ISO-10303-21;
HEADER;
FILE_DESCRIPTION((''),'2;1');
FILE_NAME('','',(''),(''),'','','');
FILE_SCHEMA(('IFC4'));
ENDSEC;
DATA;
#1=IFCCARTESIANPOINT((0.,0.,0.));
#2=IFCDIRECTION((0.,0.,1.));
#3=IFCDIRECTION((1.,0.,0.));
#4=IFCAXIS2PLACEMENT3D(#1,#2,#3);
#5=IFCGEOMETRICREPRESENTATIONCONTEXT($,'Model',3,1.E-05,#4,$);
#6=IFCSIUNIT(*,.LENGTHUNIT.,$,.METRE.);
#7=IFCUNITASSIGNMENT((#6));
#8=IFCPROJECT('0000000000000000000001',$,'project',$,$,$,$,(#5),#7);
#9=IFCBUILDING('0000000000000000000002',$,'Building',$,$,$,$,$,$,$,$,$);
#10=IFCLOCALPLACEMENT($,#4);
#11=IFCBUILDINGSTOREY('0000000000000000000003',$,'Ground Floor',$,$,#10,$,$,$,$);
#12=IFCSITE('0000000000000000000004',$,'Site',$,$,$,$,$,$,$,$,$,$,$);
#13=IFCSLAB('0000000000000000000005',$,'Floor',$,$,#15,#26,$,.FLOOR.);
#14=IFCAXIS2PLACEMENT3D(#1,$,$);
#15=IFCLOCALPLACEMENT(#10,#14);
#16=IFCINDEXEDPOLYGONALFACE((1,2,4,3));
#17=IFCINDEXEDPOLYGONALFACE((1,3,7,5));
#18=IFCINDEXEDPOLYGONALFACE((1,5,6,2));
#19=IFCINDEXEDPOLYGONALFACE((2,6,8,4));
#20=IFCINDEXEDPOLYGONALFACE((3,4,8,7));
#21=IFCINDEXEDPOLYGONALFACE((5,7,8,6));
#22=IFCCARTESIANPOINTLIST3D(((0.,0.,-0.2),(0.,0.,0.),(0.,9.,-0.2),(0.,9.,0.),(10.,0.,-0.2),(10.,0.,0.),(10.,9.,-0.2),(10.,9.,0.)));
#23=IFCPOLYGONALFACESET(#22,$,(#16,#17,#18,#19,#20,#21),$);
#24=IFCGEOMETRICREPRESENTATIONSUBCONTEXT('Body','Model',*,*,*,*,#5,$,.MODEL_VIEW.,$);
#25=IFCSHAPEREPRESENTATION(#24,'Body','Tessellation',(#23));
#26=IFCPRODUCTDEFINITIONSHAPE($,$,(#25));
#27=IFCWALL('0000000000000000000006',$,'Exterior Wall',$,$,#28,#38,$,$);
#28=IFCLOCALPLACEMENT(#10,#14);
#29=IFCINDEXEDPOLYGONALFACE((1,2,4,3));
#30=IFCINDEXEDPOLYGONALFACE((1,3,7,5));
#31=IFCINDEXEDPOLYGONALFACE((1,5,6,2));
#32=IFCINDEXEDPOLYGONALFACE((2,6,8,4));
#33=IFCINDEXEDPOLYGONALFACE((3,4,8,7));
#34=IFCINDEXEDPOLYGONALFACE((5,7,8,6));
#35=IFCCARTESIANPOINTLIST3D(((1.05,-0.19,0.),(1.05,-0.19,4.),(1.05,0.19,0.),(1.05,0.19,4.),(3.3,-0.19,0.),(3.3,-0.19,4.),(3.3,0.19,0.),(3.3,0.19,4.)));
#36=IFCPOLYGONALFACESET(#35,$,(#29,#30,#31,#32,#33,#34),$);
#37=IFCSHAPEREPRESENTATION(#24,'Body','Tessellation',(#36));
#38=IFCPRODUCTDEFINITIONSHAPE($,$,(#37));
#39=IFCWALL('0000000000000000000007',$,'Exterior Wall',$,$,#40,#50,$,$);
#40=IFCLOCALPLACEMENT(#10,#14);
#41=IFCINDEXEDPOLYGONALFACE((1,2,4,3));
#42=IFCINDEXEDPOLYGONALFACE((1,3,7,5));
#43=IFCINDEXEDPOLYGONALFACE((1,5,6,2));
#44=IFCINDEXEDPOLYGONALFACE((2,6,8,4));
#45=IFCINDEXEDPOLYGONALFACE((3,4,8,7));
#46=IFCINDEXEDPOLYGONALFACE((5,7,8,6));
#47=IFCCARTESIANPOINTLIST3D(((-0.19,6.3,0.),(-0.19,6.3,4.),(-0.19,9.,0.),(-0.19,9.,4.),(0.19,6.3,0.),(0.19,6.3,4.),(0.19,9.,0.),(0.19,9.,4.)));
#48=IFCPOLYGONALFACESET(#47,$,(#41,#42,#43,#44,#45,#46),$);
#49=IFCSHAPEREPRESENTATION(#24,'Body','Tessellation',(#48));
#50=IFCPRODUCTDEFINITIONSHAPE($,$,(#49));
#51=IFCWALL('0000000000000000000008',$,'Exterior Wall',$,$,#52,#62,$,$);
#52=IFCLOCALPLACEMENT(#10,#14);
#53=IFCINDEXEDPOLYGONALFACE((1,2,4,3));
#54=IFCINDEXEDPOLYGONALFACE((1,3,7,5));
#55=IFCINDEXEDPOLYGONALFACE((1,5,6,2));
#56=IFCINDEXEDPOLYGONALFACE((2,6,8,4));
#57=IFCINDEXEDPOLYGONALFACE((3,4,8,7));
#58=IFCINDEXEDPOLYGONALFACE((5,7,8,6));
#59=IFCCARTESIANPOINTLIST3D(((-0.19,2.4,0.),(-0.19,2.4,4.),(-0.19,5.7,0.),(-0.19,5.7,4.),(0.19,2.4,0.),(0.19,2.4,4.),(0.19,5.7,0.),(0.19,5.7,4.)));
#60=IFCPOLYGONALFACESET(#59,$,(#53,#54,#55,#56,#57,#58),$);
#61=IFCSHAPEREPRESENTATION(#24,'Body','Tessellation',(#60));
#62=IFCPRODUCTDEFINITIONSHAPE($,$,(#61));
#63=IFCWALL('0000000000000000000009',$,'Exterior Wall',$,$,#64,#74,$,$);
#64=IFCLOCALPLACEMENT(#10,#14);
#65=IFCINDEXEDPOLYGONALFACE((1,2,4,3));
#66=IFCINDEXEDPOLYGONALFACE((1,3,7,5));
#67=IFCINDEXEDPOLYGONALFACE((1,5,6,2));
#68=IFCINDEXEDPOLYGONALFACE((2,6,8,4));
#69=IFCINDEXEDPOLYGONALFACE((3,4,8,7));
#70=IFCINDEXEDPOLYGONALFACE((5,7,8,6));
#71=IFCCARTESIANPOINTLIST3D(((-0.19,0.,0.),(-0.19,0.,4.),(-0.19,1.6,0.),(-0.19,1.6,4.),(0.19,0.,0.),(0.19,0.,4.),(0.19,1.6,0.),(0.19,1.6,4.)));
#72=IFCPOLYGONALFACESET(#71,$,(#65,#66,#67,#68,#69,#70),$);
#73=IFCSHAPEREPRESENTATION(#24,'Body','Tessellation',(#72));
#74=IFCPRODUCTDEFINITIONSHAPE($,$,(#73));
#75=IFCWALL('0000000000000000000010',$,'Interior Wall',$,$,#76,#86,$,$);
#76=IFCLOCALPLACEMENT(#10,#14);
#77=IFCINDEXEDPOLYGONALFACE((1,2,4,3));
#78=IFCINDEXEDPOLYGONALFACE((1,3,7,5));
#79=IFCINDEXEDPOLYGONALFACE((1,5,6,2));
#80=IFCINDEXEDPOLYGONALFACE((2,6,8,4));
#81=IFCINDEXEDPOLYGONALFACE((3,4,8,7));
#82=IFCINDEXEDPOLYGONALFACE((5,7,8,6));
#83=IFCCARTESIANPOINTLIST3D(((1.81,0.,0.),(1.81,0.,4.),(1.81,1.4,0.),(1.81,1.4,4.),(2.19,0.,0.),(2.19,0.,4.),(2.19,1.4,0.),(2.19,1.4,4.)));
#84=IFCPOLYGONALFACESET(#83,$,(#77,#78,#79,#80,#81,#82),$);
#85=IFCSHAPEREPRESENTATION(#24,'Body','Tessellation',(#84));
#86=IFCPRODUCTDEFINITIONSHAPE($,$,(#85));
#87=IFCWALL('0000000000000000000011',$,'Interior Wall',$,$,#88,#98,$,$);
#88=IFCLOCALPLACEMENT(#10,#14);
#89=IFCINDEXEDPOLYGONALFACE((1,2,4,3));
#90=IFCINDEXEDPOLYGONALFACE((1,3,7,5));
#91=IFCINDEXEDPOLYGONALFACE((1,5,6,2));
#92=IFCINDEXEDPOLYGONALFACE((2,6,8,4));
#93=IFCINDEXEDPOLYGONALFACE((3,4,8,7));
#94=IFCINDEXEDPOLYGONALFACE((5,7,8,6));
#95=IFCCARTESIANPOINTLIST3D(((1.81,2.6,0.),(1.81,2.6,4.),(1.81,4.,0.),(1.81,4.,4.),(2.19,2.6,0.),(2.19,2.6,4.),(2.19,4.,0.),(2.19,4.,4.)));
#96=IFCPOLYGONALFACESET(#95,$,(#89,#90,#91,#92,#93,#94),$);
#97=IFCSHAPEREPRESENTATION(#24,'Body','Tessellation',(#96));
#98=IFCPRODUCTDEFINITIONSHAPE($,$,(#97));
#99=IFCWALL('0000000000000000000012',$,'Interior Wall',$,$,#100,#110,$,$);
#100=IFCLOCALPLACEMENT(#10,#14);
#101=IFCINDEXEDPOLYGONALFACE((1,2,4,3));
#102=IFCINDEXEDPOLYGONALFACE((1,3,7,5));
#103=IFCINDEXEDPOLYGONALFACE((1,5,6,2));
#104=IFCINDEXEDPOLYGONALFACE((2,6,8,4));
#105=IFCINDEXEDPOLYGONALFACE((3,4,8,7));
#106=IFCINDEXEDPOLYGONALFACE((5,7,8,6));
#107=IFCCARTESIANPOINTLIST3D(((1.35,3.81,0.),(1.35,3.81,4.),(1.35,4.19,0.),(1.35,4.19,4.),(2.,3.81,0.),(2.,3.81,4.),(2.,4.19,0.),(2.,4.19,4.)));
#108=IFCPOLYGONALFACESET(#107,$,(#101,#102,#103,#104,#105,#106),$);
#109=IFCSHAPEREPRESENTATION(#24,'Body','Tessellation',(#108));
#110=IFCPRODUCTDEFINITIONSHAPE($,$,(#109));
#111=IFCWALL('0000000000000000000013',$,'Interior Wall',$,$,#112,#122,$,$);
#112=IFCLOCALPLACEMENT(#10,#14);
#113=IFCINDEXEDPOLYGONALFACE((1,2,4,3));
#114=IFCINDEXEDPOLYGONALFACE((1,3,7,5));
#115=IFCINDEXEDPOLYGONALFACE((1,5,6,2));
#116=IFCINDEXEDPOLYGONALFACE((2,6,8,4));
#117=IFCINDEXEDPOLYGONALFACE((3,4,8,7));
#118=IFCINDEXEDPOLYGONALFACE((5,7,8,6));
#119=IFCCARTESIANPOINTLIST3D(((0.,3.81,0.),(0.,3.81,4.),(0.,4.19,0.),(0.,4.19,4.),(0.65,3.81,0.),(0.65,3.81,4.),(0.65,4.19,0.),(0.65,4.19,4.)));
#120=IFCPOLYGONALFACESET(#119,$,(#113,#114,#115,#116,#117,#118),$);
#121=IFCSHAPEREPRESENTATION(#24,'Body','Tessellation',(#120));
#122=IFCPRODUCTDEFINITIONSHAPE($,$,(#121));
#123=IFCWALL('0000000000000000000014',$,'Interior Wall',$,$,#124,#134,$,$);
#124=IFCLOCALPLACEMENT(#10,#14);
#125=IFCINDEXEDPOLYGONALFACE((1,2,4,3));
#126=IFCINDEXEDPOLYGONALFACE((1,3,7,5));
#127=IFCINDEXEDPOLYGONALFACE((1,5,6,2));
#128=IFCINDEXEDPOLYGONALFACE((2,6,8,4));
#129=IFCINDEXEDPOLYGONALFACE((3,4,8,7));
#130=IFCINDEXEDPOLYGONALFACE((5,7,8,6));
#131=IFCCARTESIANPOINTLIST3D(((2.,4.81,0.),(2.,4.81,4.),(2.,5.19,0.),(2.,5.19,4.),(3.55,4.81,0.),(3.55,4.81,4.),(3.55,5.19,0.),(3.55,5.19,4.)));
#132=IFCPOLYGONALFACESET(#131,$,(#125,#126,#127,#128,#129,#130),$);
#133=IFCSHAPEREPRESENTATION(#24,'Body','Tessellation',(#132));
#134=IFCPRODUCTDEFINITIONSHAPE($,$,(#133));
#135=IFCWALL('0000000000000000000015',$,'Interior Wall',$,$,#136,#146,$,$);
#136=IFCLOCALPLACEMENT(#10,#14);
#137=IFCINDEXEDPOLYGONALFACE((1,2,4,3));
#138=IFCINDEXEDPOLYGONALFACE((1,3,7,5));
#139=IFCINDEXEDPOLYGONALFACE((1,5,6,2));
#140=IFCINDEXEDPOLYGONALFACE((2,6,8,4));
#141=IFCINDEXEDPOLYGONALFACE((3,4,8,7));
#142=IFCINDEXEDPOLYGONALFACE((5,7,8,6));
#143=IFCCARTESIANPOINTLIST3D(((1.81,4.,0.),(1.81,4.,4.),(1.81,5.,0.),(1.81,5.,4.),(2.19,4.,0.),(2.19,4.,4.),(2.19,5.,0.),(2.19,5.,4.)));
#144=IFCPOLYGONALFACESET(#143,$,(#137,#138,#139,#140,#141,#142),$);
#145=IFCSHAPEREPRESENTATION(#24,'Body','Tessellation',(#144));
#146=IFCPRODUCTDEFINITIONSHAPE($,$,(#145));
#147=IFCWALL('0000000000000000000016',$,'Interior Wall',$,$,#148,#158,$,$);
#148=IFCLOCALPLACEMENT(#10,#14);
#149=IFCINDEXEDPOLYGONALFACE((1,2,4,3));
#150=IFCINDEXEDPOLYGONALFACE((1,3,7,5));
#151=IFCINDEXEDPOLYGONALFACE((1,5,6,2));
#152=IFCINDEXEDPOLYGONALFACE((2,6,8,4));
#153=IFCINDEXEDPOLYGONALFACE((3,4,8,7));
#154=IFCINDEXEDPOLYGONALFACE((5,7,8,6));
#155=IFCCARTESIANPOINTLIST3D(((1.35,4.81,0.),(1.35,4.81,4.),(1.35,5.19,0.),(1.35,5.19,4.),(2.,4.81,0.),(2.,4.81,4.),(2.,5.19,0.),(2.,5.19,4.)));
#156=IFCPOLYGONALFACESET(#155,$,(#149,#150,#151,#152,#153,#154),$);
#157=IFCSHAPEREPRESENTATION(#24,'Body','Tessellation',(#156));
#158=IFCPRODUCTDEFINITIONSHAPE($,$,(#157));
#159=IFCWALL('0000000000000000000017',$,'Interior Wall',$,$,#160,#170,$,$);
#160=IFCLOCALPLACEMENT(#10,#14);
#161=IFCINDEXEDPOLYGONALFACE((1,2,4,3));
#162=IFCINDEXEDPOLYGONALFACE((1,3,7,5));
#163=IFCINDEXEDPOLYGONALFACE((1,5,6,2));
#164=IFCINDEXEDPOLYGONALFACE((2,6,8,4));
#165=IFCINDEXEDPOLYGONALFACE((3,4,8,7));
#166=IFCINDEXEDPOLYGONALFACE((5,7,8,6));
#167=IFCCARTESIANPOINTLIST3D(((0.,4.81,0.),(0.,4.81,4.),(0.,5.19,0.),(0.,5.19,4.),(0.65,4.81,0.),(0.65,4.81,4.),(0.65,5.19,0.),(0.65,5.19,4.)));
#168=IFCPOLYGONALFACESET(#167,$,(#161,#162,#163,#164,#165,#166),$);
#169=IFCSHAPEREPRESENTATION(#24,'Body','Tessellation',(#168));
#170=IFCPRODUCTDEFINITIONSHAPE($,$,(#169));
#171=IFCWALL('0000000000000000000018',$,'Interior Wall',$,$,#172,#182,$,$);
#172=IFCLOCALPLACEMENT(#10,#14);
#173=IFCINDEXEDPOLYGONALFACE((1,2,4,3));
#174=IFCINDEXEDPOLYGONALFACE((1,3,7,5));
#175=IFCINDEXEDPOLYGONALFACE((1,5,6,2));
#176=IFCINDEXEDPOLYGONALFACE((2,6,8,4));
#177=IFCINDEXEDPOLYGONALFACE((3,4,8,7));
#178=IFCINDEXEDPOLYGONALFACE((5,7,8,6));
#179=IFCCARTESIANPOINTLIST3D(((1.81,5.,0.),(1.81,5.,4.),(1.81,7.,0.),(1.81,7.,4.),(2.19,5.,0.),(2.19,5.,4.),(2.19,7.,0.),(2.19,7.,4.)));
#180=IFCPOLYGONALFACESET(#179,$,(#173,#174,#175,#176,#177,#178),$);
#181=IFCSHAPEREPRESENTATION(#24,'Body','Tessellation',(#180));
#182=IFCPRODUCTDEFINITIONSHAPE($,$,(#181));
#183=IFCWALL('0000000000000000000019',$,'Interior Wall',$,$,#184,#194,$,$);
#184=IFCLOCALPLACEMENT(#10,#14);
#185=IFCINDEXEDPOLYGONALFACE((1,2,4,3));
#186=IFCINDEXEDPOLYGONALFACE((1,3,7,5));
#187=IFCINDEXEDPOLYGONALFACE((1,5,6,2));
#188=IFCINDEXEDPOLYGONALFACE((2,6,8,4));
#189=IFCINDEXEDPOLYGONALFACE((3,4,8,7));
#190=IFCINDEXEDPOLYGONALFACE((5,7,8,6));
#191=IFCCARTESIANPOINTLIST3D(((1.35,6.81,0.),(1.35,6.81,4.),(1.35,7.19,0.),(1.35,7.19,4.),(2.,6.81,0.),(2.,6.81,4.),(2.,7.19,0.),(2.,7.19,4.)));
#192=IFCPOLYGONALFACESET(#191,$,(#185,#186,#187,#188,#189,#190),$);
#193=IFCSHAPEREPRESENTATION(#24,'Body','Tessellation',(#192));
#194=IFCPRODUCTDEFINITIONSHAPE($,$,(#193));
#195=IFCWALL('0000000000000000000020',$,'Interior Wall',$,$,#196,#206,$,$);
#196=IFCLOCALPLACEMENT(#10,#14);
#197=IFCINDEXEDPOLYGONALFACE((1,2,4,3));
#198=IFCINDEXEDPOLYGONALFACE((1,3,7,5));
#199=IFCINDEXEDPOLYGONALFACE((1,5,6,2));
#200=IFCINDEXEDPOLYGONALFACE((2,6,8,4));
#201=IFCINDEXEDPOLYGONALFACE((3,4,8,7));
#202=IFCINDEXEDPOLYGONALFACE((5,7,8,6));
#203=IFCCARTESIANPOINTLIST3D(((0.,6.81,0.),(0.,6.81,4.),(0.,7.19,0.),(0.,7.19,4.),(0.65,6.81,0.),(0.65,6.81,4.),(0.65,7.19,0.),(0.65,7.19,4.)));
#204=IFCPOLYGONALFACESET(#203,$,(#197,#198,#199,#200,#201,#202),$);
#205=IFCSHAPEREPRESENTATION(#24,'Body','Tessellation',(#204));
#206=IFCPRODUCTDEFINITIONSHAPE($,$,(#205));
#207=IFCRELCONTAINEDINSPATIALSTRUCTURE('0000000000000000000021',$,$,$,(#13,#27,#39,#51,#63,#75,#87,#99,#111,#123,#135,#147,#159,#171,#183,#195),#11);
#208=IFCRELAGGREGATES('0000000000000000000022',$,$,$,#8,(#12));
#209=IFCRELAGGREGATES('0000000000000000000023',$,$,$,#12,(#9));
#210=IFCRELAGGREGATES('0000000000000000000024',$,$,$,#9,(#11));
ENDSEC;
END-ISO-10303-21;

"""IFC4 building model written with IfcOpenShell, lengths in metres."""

from ifc_helpers import new_model, si_unit, frame, origin_with_axes, place, context, subcontext, project, spatial, indexed_curve, outline, extrude, element, save


model = new_model("IFC4")

# Units and contexts
model_context = context("Model", 3, precision=1e-05, world=origin_with_axes())
body_context = subcontext(model_context, "Body", "Model", "MODEL_VIEW")
ifc_project = project(units=[si_unit("LENGTHUNIT", "METRE")], contexts=[model_context])

# Site, building, storey
site = spatial("IfcSite", under=ifc_project, Name="Site")
building = spatial("IfcBuilding", under=site, Name="Building")
storey_placement = place(None, origin_with_axes())
storey = spatial("IfcBuildingStorey", under=building, at=storey_placement, Name="Ground Floor")

# Slab
slab_placement = place(storey_placement, frame((0.0, 0.0, -0.2), z_axis=(0.0, 0.0, 1.0), x_axis=(1.0, 0.0, 0.0)))
element("IfcSlab", 1, at=slab_placement, inside=storey, Name="Floor", PredefinedType="FLOOR", context=body_context, shape_type="SweptSolid", body=[
    extrude(outline(indexed_curve([(0.0, 0.0), (10.0, 0.0), (10.0, 9.0), (0.0, 9.0)])), None, (0.0, 0.0, 1.0), 0.2),
])

# Walls
wall_1_placement = place(storey_placement, frame((1.05, 0.0, 0.0), z_axis=(0.0, 0.0, 1.0), x_axis=(1.0, 0.0, 0.0)))
element("IfcWall", 2, at=wall_1_placement, inside=storey, Name="Exterior Wall", context=body_context, shape_type="SweptSolid", body=[
    extrude(outline(indexed_curve([(0.0, 0.0), (0.0, 0.38), (2.25, 0.38), (2.25, 0.0), (0.0, 0.0)], self_intersect=False)), frame((0.0, -0.19, 0.0), z_axis=(0.0, 0.0, 1.0), x_axis=(1.0, 0.0, 0.0)), (0.0, 0.0, 1.0), 4.0),
])
wall_2_placement = place(storey_placement, frame((0.0, 9.0, 0.0), z_axis=(0.0, 0.0, 1.0), x_axis=(0.0, -1.0, 0.0)))
element("IfcWall", 3, at=wall_2_placement, inside=storey, Name="Exterior Wall", context=body_context, shape_type="SweptSolid", body=[
    extrude(outline(indexed_curve([(0.0, 0.0), (0.0, 0.38), (2.7, 0.38), (2.7, 0.0), (0.0, 0.0)], self_intersect=False)), frame((0.0, -0.19, 0.0), z_axis=(0.0, 0.0, 1.0), x_axis=(1.0, 0.0, 0.0)), (0.0, 0.0, 1.0), 4.0),
])
wall_3_placement = place(storey_placement, frame((0.0, 5.7, 0.0), z_axis=(0.0, 0.0, 1.0), x_axis=(0.0, -1.0, 0.0)))
element("IfcWall", 4, at=wall_3_placement, inside=storey, Name="Exterior Wall", context=body_context, shape_type="SweptSolid", body=[
    extrude(outline(indexed_curve([(0.0, 0.0), (0.0, 0.38), (3.3, 0.38), (3.3, 0.0), (0.0, 0.0)], self_intersect=False)), frame((0.0, -0.19, 0.0), z_axis=(0.0, 0.0, 1.0), x_axis=(1.0, 0.0, 0.0)), (0.0, 0.0, 1.0), 4.0),
])
wall_4_placement = place(storey_placement, frame((0.0, 1.6, 0.0), z_axis=(0.0, 0.0, 1.0), x_axis=(0.0, -1.0, 0.0)))
element("IfcWall", 5, at=wall_4_placement, inside=storey, Name="Exterior Wall", context=body_context, shape_type="SweptSolid", body=[
    extrude(outline(indexed_curve([(0.0, 0.0), (0.0, 0.38), (1.6, 0.38), (1.6, 0.0), (0.0, 0.0)], self_intersect=False)), frame((0.0, -0.19, 0.0), z_axis=(0.0, 0.0, 1.0), x_axis=(1.0, 0.0, 0.0)), (0.0, 0.0, 1.0), 4.0),
])
for number, where, z_axis, x_axis, name in (
    (6, (2.0, 0.0, 0.0), (0.0, 0.0, 1.0), (0.0, 1.0, 0.0), "Interior Wall"),
    (7, (2.0, 2.6, 0.0), (0.0, 0.0, 1.0), (0.0, 1.0, 0.0), "Interior Wall"),
):
    element("IfcWall", number, at=place(storey_placement, frame(where, z_axis=z_axis, x_axis=x_axis)), inside=storey, Name=name, context=body_context, shape_type="SweptSolid", body=[
        extrude(outline(indexed_curve([(0.0, 0.0), (0.0, 0.38), (1.4, 0.38), (1.4, 0.0), (0.0, 0.0)], self_intersect=False)), frame((0.0, -0.19, 0.0), z_axis=(0.0, 0.0, 1.0), x_axis=(1.0, 0.0, 0.0)), (0.0, 0.0, 1.0), 4.0),
    ])
for number, where, z_axis, x_axis, name in (
    (8, (2.0, 4.0, 0.0), (0.0, 0.0, 1.0), (-1.0, 0.0, 0.0), "Interior Wall"),
    (9, (0.65, 4.0, 0.0), (0.0, 0.0, 1.0), (-1.0, 0.0, 0.0), "Interior Wall"),
):
    element("IfcWall", number, at=place(storey_placement, frame(where, z_axis=z_axis, x_axis=x_axis)), inside=storey, Name=name, context=body_context, shape_type="SweptSolid", body=[
        extrude(outline(indexed_curve([(0.0, 0.0), (0.0, 0.38), (0.65, 0.38), (0.65, 0.0), (0.0, 0.0)], self_intersect=False)), frame((0.0, -0.19, 0.0), z_axis=(0.0, 0.0, 1.0), x_axis=(1.0, 0.0, 0.0)), (0.0, 0.0, 1.0), 4.0),
    ])
wall_5_placement = place(storey_placement, frame((3.55, 5.0, 0.0), z_axis=(0.0, 0.0, 1.0), x_axis=(-1.0, 0.0, 0.0)))
element("IfcWall", 10, at=wall_5_placement, inside=storey, Name="Interior Wall", context=body_context, shape_type="SweptSolid", body=[
    extrude(outline(indexed_curve([(0.0, 0.0), (0.0, 0.38), (1.55, 0.38), (1.55, 0.0), (0.0, 0.0)], self_intersect=False)), frame((0.0, -0.19, 0.0), z_axis=(0.0, 0.0, 1.0), x_axis=(1.0, 0.0, 0.0)), (0.0, 0.0, 1.0), 4.0),
])
wall_6_placement = place(storey_placement, frame((2.0, 5.0, 0.0), z_axis=(0.0, 0.0, 1.0), x_axis=(0.0, -1.0, 0.0)))
element("IfcWall", 11, at=wall_6_placement, inside=storey, Name="Interior Wall", context=body_context, shape_type="SweptSolid", body=[
    extrude(outline(indexed_curve([(0.0, 0.0), (0.0, 0.38), (1.0, 0.38), (1.0, 0.0), (0.0, 0.0)], self_intersect=False)), frame((0.0, -0.19, 0.0), z_axis=(0.0, 0.0, 1.0), x_axis=(1.0, 0.0, 0.0)), (0.0, 0.0, 1.0), 4.0),
])
for number, where, z_axis, x_axis, name in (
    (12, (2.0, 5.0, 0.0), (0.0, 0.0, 1.0), (-1.0, 0.0, 0.0), "Interior Wall"),
    (13, (0.65, 5.0, 0.0), (0.0, 0.0, 1.0), (-1.0, 0.0, 0.0), "Interior Wall"),
):
    element("IfcWall", number, at=place(storey_placement, frame(where, z_axis=z_axis, x_axis=x_axis)), inside=storey, Name=name, context=body_context, shape_type="SweptSolid", body=[
        extrude(outline(indexed_curve([(0.0, 0.0), (0.0, 0.38), (0.65, 0.38), (0.65, 0.0), (0.0, 0.0)], self_intersect=False)), frame((0.0, -0.19, 0.0), z_axis=(0.0, 0.0, 1.0), x_axis=(1.0, 0.0, 0.0)), (0.0, 0.0, 1.0), 4.0),
    ])
wall_7_placement = place(storey_placement, frame((2.0, 5.0, 0.0), z_axis=(0.0, 0.0, 1.0), x_axis=(0.0, 1.0, 0.0)))
element("IfcWall", 14, at=wall_7_placement, inside=storey, Name="Interior Wall", context=body_context, shape_type="SweptSolid", body=[
    extrude(outline(indexed_curve([(0.0, 0.0), (0.0, 0.38), (2.0, 0.38), (2.0, 0.0), (0.0, 0.0)], self_intersect=False)), frame((0.0, -0.19, 0.0), z_axis=(0.0, 0.0, 1.0), x_axis=(1.0, 0.0, 0.0)), (0.0, 0.0, 1.0), 4.0),
])
for number, where, z_axis, x_axis, name in (
    (15, (2.0, 7.0, 0.0), (0.0, 0.0, 1.0), (-1.0, 0.0, 0.0), "Interior Wall"),
    (16, (0.65, 7.0, 0.0), (0.0, 0.0, 1.0), (-1.0, 0.0, 0.0), "Interior Wall"),
):
    element("IfcWall", number, at=place(storey_placement, frame(where, z_axis=z_axis, x_axis=x_axis)), inside=storey, Name=name, context=body_context, shape_type="SweptSolid", body=[
        extrude(outline(indexed_curve([(0.0, 0.0), (0.0, 0.38), (0.65, 0.38), (0.65, 0.0), (0.0, 0.0)], self_intersect=False)), frame((0.0, -0.19, 0.0), z_axis=(0.0, 0.0, 1.0), x_axis=(1.0, 0.0, 0.0)), (0.0, 0.0, 1.0), 4.0),
    ])

save(model, "model.ifc")
